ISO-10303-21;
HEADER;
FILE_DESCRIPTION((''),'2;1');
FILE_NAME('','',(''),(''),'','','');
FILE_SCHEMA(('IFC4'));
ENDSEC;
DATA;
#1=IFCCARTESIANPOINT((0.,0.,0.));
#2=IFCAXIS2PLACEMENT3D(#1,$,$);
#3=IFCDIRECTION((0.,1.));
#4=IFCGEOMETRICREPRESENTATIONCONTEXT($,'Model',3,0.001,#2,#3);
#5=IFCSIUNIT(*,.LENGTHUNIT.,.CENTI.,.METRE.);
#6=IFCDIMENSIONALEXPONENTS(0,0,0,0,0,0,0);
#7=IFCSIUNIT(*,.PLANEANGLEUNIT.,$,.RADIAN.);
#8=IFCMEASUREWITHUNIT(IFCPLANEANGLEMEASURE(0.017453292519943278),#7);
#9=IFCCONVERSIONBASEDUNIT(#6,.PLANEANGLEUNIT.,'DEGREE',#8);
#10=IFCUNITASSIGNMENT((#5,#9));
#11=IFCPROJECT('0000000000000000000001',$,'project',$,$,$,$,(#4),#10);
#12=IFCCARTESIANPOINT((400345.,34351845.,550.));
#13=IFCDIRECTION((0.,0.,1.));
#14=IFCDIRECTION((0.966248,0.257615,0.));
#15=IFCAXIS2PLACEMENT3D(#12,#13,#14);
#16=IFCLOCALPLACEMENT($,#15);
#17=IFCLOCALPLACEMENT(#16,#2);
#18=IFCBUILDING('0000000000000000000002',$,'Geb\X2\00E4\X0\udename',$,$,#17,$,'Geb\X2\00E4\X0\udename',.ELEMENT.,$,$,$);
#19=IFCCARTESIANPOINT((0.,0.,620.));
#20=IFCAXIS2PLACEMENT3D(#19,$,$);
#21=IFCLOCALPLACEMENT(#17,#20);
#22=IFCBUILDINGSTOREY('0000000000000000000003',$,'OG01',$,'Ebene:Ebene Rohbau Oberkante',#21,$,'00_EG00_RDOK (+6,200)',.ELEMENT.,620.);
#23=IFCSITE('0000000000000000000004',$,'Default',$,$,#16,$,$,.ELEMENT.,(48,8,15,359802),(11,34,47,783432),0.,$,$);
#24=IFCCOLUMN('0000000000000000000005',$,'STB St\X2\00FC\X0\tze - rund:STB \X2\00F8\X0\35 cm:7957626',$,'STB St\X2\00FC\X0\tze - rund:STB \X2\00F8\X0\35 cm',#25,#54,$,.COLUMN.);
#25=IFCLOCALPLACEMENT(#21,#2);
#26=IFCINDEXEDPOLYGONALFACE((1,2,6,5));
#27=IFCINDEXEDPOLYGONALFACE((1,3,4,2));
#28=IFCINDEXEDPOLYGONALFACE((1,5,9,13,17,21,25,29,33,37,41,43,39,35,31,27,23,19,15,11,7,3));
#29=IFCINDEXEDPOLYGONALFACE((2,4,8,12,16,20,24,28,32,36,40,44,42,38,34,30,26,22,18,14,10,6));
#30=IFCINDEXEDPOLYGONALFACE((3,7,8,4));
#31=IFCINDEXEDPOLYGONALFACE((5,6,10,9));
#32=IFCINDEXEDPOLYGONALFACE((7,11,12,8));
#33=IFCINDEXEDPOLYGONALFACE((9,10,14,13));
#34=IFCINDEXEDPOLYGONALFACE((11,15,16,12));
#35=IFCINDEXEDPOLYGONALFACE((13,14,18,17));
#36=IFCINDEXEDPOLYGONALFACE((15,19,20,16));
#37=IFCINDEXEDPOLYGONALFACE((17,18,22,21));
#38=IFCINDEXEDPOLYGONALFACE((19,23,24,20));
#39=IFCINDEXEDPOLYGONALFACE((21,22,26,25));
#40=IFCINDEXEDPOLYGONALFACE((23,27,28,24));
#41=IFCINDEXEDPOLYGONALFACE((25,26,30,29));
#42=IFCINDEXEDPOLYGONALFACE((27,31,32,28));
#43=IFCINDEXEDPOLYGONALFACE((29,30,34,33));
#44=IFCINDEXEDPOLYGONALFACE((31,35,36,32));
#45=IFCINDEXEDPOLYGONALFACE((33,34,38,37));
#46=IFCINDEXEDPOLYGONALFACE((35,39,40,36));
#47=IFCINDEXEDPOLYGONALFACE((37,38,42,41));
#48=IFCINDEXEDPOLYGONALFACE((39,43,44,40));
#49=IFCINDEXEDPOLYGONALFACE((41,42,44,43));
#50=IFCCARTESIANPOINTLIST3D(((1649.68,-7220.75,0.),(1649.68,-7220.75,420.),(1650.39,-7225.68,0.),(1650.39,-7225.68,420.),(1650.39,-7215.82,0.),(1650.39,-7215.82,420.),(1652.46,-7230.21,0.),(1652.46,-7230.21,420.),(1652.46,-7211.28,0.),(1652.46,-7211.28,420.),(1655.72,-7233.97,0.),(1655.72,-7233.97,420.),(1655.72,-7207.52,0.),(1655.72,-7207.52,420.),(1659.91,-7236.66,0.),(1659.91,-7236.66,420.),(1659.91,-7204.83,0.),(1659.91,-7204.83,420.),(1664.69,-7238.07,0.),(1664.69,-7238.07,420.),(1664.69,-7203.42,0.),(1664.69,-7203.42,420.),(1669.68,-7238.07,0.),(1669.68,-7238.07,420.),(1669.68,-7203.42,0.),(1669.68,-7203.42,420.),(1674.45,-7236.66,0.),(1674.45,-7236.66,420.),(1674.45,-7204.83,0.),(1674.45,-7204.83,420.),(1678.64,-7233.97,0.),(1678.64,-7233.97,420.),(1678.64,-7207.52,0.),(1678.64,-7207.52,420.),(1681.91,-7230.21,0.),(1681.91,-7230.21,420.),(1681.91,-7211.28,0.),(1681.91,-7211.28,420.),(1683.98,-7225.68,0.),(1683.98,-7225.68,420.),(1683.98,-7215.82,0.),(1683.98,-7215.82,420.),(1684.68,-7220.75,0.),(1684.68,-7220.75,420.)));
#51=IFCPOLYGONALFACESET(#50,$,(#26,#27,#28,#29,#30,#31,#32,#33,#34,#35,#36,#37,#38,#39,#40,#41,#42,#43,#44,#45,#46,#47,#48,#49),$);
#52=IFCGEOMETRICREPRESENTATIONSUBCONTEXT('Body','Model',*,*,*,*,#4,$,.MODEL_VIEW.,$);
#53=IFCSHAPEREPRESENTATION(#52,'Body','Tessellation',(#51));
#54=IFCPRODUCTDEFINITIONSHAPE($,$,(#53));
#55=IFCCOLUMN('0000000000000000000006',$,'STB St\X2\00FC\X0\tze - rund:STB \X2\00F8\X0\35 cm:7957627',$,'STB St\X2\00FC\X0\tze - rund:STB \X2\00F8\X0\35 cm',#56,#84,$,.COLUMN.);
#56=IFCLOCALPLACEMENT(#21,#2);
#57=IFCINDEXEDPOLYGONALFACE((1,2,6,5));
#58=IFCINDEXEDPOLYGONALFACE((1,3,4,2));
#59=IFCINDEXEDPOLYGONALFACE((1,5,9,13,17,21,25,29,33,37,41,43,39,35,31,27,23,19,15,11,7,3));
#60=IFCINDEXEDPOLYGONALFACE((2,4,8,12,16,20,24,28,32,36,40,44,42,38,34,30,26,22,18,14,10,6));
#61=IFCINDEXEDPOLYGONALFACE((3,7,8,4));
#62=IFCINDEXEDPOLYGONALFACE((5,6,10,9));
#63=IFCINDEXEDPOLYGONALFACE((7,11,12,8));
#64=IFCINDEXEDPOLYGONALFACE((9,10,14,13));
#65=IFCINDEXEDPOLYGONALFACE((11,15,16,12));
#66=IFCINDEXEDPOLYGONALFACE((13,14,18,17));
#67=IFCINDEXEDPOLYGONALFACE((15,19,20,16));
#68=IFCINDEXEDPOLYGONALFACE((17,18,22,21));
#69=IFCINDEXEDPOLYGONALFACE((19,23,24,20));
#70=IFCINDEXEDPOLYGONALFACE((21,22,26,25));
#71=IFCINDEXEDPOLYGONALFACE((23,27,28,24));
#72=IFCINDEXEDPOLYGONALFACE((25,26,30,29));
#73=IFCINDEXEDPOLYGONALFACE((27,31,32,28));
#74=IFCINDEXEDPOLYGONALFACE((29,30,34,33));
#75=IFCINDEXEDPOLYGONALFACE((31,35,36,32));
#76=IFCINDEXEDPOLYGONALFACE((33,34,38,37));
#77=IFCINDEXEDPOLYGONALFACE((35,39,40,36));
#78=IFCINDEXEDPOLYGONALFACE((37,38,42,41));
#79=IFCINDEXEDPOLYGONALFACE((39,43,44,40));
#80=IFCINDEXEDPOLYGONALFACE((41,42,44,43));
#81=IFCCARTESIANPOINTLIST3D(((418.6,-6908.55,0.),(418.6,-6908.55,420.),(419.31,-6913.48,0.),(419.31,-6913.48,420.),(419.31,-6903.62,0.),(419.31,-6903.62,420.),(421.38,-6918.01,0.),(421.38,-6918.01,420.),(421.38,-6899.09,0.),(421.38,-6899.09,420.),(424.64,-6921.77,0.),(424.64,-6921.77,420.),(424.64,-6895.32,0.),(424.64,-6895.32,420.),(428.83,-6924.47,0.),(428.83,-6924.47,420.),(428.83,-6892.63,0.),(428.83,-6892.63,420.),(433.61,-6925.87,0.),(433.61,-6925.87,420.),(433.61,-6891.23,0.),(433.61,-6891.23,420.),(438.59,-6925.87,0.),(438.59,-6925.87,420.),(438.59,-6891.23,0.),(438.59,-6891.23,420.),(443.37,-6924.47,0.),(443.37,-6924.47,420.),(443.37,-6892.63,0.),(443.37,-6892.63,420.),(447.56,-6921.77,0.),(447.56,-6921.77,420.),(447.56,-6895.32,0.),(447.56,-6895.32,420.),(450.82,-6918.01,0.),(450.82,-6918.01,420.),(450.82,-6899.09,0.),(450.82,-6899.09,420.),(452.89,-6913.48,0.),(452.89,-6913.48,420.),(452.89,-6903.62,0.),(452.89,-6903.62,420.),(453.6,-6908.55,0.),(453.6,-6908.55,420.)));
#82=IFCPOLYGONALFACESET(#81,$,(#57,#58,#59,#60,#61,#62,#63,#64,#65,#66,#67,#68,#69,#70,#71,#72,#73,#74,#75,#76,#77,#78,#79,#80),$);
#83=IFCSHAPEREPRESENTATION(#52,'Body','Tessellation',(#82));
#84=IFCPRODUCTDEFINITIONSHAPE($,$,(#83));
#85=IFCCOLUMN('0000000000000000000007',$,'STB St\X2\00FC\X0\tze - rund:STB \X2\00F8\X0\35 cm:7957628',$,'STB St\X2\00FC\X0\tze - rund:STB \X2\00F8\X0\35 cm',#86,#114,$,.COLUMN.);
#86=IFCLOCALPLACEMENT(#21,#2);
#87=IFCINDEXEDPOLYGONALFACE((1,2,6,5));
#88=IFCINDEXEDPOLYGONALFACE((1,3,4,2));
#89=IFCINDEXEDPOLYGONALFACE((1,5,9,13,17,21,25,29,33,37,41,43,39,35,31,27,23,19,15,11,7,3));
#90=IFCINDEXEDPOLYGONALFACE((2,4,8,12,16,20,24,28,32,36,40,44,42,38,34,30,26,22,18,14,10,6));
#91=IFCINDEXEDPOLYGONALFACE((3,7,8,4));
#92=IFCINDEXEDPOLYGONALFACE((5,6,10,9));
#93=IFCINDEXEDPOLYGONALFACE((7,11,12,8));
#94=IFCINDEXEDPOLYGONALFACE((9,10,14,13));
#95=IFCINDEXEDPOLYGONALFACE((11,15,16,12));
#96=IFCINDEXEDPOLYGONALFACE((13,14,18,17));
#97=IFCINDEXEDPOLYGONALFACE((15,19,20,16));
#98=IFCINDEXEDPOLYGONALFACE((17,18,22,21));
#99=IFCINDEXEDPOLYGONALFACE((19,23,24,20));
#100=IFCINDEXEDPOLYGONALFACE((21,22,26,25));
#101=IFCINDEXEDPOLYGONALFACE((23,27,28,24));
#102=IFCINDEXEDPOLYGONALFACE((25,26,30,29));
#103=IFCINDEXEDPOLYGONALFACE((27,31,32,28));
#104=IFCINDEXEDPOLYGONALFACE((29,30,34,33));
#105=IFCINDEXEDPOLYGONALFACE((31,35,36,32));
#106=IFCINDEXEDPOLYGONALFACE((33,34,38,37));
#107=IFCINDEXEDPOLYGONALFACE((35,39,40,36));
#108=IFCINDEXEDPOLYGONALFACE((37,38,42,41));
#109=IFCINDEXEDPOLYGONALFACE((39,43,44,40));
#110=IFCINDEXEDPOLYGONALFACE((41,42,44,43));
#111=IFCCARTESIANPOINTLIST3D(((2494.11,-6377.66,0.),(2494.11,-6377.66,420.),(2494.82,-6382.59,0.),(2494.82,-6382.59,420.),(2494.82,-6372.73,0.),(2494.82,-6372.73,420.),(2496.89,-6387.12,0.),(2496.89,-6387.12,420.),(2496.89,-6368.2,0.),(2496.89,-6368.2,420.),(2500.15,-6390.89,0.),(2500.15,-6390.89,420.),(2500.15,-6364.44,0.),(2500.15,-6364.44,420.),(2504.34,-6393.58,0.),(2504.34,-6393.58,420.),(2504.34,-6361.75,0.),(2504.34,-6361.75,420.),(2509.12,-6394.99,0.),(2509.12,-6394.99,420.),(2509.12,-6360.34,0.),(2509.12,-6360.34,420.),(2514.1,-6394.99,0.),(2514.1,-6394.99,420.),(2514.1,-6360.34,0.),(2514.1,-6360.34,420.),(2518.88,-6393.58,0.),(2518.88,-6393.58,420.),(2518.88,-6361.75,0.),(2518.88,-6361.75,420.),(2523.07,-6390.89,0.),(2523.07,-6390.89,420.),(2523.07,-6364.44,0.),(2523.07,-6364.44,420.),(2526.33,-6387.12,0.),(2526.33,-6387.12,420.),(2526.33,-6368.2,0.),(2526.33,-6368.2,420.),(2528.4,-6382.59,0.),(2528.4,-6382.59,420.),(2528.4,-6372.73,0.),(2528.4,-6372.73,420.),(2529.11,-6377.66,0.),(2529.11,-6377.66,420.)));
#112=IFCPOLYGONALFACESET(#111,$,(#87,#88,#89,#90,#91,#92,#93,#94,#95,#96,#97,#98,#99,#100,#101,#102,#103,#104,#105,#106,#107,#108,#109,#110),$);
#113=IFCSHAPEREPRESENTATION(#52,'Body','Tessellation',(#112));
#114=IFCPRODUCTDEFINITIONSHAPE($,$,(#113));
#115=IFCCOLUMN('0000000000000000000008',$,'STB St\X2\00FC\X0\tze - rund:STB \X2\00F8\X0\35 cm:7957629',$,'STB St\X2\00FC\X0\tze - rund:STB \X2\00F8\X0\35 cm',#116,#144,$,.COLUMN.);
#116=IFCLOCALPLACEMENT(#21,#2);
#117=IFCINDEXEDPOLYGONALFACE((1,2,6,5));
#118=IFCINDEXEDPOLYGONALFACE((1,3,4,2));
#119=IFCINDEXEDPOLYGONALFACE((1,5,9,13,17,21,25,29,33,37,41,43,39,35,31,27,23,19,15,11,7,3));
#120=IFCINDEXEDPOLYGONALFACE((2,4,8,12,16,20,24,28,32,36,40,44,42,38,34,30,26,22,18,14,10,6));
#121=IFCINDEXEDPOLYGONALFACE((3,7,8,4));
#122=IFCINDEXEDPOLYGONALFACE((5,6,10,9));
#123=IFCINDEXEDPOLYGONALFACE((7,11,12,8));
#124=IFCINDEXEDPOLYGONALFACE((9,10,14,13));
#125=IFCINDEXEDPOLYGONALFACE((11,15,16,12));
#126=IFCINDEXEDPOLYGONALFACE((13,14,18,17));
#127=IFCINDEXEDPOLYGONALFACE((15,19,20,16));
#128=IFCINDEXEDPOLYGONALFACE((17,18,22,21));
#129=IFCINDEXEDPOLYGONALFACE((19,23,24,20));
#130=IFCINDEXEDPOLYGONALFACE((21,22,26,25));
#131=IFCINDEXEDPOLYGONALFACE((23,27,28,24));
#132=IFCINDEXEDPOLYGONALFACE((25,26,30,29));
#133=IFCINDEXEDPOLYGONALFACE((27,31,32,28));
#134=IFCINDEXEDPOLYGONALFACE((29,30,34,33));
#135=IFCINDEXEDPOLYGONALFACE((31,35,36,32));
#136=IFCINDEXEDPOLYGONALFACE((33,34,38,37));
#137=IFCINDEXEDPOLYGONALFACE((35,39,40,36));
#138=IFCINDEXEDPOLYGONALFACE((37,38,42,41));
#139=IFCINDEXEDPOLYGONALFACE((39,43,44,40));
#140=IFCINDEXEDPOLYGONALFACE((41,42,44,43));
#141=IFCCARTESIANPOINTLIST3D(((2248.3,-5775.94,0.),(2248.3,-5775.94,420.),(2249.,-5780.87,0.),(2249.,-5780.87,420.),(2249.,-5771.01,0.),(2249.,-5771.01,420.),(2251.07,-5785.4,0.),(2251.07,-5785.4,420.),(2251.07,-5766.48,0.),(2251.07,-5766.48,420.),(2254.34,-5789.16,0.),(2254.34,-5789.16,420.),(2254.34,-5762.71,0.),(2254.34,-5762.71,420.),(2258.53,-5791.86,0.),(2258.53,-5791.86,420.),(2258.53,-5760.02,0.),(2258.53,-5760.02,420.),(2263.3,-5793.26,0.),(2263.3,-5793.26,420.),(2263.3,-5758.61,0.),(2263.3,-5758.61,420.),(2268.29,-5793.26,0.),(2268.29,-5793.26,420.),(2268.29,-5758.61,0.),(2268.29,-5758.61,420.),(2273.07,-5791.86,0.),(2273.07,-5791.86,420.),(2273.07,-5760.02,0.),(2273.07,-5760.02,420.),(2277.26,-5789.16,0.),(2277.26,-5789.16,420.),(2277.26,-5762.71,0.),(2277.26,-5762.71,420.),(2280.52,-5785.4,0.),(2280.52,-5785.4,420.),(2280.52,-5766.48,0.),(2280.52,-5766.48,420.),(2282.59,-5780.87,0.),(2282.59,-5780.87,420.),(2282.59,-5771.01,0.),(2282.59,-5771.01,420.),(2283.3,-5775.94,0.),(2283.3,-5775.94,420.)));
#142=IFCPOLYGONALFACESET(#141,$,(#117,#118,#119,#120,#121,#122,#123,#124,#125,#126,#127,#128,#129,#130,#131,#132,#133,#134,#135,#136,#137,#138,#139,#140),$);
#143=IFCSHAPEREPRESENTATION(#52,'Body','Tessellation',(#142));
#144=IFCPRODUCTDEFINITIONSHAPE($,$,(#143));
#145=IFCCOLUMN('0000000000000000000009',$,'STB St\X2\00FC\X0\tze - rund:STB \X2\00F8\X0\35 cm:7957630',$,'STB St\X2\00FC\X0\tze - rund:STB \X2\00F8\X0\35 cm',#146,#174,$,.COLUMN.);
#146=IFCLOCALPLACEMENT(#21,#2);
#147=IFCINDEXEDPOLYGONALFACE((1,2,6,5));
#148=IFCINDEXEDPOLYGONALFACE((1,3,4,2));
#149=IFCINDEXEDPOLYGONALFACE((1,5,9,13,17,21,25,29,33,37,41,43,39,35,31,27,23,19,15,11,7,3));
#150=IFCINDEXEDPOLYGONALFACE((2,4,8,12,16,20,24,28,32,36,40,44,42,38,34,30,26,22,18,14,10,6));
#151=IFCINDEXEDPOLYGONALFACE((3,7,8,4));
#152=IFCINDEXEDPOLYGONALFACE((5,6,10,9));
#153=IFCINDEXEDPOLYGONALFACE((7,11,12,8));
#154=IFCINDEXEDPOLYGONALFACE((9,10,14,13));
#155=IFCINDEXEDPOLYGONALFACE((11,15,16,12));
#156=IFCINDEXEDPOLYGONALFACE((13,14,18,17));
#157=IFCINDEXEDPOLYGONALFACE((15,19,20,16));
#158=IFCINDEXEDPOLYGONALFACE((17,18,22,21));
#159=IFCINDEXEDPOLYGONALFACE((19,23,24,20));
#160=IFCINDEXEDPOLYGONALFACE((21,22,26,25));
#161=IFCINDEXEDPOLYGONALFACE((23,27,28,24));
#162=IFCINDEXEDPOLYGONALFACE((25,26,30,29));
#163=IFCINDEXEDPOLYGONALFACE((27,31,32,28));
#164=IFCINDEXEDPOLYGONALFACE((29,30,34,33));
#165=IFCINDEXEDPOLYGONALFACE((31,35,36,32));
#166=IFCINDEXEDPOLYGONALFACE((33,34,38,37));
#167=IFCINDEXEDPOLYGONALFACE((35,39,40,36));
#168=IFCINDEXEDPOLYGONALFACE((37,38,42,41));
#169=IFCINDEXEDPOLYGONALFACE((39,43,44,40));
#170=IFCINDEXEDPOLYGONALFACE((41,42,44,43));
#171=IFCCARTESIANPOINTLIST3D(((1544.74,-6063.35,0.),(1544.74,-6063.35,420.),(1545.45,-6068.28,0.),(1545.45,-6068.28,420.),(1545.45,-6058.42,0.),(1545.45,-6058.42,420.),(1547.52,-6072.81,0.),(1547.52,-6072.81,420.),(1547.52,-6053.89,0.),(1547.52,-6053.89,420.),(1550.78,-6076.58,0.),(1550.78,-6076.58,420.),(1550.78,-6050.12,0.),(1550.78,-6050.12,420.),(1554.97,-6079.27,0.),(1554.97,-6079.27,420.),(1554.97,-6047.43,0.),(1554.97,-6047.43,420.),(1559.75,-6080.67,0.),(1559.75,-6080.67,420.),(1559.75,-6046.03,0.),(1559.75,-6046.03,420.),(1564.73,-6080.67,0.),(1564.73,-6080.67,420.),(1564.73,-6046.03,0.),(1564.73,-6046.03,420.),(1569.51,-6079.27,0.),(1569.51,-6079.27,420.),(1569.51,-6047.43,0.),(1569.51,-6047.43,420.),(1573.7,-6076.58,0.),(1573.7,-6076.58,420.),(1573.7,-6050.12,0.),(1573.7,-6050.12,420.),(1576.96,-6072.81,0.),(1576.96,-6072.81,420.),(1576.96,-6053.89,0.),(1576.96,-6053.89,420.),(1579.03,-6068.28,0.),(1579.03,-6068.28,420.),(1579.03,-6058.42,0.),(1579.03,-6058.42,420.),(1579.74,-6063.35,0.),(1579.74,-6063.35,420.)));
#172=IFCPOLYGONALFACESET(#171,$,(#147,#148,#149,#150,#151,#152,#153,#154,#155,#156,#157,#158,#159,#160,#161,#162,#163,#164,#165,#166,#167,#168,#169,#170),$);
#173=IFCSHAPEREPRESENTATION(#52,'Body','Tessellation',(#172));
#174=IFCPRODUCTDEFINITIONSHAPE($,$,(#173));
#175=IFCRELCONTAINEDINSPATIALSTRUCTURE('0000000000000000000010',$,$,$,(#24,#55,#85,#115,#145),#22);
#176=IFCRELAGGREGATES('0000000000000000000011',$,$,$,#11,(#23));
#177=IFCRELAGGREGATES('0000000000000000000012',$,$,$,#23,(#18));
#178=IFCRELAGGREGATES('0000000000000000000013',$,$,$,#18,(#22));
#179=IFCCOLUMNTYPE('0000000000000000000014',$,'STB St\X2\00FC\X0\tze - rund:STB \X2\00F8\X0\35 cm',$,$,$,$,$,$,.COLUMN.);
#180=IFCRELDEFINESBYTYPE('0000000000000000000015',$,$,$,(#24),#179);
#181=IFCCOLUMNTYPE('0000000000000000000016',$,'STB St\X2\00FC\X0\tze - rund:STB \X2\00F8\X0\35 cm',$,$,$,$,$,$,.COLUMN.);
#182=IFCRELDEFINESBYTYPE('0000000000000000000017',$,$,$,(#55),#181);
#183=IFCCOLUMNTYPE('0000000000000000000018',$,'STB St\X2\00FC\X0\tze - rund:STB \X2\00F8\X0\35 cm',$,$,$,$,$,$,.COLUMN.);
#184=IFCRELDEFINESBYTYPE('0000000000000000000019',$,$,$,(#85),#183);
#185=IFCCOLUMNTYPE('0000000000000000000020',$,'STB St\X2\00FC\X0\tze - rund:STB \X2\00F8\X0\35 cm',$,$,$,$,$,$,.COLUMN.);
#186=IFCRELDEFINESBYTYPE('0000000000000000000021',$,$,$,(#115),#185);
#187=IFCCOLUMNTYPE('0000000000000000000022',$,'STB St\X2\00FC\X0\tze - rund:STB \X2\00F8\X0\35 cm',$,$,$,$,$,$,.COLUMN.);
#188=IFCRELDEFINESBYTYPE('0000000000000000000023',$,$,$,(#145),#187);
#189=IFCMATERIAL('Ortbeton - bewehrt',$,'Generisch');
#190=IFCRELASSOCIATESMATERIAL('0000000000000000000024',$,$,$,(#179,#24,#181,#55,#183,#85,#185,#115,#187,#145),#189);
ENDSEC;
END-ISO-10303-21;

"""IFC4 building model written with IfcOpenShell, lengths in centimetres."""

from ifc_helpers import new_model, entity, si_unit, converted_unit, direction, frame, origin, place, context, subcontext, project, spatial, arc, indexed_curve, outline, extrude, source, transform, mapped, material, type_object, type_shapes, element, save


model = new_model("IFC4")

# Units and contexts
model_context = context("Model", 3, precision=0.001, world=origin(), true_north=direction((0.0, 1.0)))
body_context = subcontext(model_context, "Body", "Model", "MODEL_VIEW")
ifc_project = project(units=[si_unit("LENGTHUNIT", "METRE", prefix="CENTI"), converted_unit("PLANEANGLEUNIT", "DEGREE", entity("IfcPlaneAngleMeasure", 0.017453292519943278), si_unit("PLANEANGLEUNIT", "RADIAN"), dimensions=[0, 0, 0, 0, 0, 0, 0])], contexts=[model_context])

# Site, building, storey
site_placement = place(None, frame((400345.0, 34351845.0, 550.0), z_axis=(0.0, 0.0, 1.0), x_axis=(0.966248, 0.257615, 0.0)))
site = spatial("IfcSite", under=ifc_project, at=site_placement, Name="Default", CompositionType="ELEMENT", RefLatitude=(48, 8, 15, 359802), RefLongitude=(11, 34, 47, 783432), RefElevation=0.0)
building_placement = place(site_placement, origin())
building = spatial("IfcBuilding", under=site, at=building_placement, Name="Gebäudename", LongName="Gebäudename", CompositionType="ELEMENT")
storey_placement = place(building_placement, frame((0.0, 0.0, 620.0)))
storey = spatial("IfcBuildingStorey", under=building, at=storey_placement, Name="OG01", ObjectType="Ebene:Ebene Rohbau Oberkante", LongName="00_EG00_RDOK (+6,200)", CompositionType="ELEMENT", Elevation=620.0)

# Columns
ifc_material = material(Name="Ortbeton - bewehrt", Category="Generisch")
column_type_1 = type_object("IfcColumnType", Name="STB Stütze - rund:STB ø35 cm", PredefinedType="COLUMN", material=ifc_material)
shared_shape_1 = source(origin(), body_context, "Body", "SweptSolid", [
    extrude(outline(indexed_curve([(-17.5, 0.0), (0.0, -17.5), (17.5, 0.0), (0.0, 17.5)], segments=[arc(1, 2, 3), arc(3, 4, 1)], self_intersect=False)), frame((1667.18, -7220.75, 620.0)), (0.0, 0.0, 1.0), 420.0),
])
type_shapes(column_type_1, [shared_shape_1])
column_1_placement = place(storey_placement, frame((0.0, 0.0, -620.0)))
element("IfcColumn", 1, at=column_1_placement, inside=storey, type_object=column_type_1, material=ifc_material, Name="STB Stütze - rund:STB ø35 cm:7957626", ObjectType="STB Stütze - rund:STB ø35 cm", PredefinedType="COLUMN", context=body_context, shape_type="MappedRepresentation", body=[
    mapped(shared_shape_1, transform((0.0, 0.0, 0.0), scale=1.0)),
])
column_type_2 = type_object("IfcColumnType", Name="STB Stütze - rund:STB ø35 cm", PredefinedType="COLUMN", material=ifc_material)
shared_shape_2 = source(origin(), body_context, "Body", "SweptSolid", [
    extrude(outline(indexed_curve([(-17.5, 0.0), (0.0, -17.5), (17.5, 0.0), (0.0, 17.5)], segments=[arc(1, 2, 3), arc(3, 4, 1)], self_intersect=False)), frame((436.1, -6908.55, 620.0)), (0.0, 0.0, 1.0), 420.0),
])
type_shapes(column_type_2, [shared_shape_2])
column_2_placement = place(storey_placement, frame((0.0, 0.0, -620.0)))
element("IfcColumn", 2, at=column_2_placement, inside=storey, type_object=column_type_2, material=ifc_material, Name="STB Stütze - rund:STB ø35 cm:7957627", ObjectType="STB Stütze - rund:STB ø35 cm", PredefinedType="COLUMN", context=body_context, shape_type="MappedRepresentation", body=[
    mapped(shared_shape_2, transform((0.0, 0.0, 0.0), scale=1.0)),
])
column_type_3 = type_object("IfcColumnType", Name="STB Stütze - rund:STB ø35 cm", PredefinedType="COLUMN", material=ifc_material)
shared_shape_3 = source(origin(), body_context, "Body", "SweptSolid", [
    extrude(outline(indexed_curve([(-17.5, 0.0), (0.0, -17.5), (17.5, 0.0), (0.0, 17.5)], segments=[arc(1, 2, 3), arc(3, 4, 1)], self_intersect=False)), frame((2511.61, -6377.66, 620.0)), (0.0, 0.0, 1.0), 420.0),
])
type_shapes(column_type_3, [shared_shape_3])
column_3_placement = place(storey_placement, frame((0.0, 0.0, -620.0)))
element("IfcColumn", 3, at=column_3_placement, inside=storey, type_object=column_type_3, material=ifc_material, Name="STB Stütze - rund:STB ø35 cm:7957628", ObjectType="STB Stütze - rund:STB ø35 cm", PredefinedType="COLUMN", context=body_context, shape_type="MappedRepresentation", body=[
    mapped(shared_shape_3, transform((0.0, 0.0, 0.0), scale=1.0)),
])
column_type_4 = type_object("IfcColumnType", Name="STB Stütze - rund:STB ø35 cm", PredefinedType="COLUMN", material=ifc_material)
shared_shape_4 = source(origin(), body_context, "Body", "SweptSolid", [
    extrude(outline(indexed_curve([(-17.5, 0.0), (0.0, -17.5), (17.5, 0.0), (0.0, 17.5)], segments=[arc(1, 2, 3), arc(3, 4, 1)], self_intersect=False)), frame((2265.8, -5775.94, 620.0)), (0.0, 0.0, 1.0), 420.0),
])
type_shapes(column_type_4, [shared_shape_4])
column_4_placement = place(storey_placement, frame((0.0, 0.0, -620.0)))
element("IfcColumn", 4, at=column_4_placement, inside=storey, type_object=column_type_4, material=ifc_material, Name="STB Stütze - rund:STB ø35 cm:7957629", ObjectType="STB Stütze - rund:STB ø35 cm", PredefinedType="COLUMN", context=body_context, shape_type="MappedRepresentation", body=[
    mapped(shared_shape_4, transform((0.0, 0.0, 0.0), scale=1.0)),
])
column_type_5 = type_object("IfcColumnType", Name="STB Stütze - rund:STB ø35 cm", PredefinedType="COLUMN", material=ifc_material)
shared_shape_5 = source(origin(), body_context, "Body", "SweptSolid", [
    extrude(outline(indexed_curve([(-17.5, 0.0), (0.0, -17.5), (17.5, 0.0), (0.0, 17.5)], segments=[arc(1, 2, 3), arc(3, 4, 1)], self_intersect=False)), frame((1562.24, -6063.35, 620.0)), (0.0, 0.0, 1.0), 420.0),
])
type_shapes(column_type_5, [shared_shape_5])
column_5_placement = place(storey_placement, frame((0.0, 0.0, -620.0)))
element("IfcColumn", 5, at=column_5_placement, inside=storey, type_object=column_type_5, material=ifc_material, Name="STB Stütze - rund:STB ø35 cm:7957630", ObjectType="STB Stütze - rund:STB ø35 cm", PredefinedType="COLUMN", context=body_context, shape_type="MappedRepresentation", body=[
    mapped(shared_shape_5, transform((0.0, 0.0, 0.0), scale=1.0)),
])

save(model, "model.ifc")
